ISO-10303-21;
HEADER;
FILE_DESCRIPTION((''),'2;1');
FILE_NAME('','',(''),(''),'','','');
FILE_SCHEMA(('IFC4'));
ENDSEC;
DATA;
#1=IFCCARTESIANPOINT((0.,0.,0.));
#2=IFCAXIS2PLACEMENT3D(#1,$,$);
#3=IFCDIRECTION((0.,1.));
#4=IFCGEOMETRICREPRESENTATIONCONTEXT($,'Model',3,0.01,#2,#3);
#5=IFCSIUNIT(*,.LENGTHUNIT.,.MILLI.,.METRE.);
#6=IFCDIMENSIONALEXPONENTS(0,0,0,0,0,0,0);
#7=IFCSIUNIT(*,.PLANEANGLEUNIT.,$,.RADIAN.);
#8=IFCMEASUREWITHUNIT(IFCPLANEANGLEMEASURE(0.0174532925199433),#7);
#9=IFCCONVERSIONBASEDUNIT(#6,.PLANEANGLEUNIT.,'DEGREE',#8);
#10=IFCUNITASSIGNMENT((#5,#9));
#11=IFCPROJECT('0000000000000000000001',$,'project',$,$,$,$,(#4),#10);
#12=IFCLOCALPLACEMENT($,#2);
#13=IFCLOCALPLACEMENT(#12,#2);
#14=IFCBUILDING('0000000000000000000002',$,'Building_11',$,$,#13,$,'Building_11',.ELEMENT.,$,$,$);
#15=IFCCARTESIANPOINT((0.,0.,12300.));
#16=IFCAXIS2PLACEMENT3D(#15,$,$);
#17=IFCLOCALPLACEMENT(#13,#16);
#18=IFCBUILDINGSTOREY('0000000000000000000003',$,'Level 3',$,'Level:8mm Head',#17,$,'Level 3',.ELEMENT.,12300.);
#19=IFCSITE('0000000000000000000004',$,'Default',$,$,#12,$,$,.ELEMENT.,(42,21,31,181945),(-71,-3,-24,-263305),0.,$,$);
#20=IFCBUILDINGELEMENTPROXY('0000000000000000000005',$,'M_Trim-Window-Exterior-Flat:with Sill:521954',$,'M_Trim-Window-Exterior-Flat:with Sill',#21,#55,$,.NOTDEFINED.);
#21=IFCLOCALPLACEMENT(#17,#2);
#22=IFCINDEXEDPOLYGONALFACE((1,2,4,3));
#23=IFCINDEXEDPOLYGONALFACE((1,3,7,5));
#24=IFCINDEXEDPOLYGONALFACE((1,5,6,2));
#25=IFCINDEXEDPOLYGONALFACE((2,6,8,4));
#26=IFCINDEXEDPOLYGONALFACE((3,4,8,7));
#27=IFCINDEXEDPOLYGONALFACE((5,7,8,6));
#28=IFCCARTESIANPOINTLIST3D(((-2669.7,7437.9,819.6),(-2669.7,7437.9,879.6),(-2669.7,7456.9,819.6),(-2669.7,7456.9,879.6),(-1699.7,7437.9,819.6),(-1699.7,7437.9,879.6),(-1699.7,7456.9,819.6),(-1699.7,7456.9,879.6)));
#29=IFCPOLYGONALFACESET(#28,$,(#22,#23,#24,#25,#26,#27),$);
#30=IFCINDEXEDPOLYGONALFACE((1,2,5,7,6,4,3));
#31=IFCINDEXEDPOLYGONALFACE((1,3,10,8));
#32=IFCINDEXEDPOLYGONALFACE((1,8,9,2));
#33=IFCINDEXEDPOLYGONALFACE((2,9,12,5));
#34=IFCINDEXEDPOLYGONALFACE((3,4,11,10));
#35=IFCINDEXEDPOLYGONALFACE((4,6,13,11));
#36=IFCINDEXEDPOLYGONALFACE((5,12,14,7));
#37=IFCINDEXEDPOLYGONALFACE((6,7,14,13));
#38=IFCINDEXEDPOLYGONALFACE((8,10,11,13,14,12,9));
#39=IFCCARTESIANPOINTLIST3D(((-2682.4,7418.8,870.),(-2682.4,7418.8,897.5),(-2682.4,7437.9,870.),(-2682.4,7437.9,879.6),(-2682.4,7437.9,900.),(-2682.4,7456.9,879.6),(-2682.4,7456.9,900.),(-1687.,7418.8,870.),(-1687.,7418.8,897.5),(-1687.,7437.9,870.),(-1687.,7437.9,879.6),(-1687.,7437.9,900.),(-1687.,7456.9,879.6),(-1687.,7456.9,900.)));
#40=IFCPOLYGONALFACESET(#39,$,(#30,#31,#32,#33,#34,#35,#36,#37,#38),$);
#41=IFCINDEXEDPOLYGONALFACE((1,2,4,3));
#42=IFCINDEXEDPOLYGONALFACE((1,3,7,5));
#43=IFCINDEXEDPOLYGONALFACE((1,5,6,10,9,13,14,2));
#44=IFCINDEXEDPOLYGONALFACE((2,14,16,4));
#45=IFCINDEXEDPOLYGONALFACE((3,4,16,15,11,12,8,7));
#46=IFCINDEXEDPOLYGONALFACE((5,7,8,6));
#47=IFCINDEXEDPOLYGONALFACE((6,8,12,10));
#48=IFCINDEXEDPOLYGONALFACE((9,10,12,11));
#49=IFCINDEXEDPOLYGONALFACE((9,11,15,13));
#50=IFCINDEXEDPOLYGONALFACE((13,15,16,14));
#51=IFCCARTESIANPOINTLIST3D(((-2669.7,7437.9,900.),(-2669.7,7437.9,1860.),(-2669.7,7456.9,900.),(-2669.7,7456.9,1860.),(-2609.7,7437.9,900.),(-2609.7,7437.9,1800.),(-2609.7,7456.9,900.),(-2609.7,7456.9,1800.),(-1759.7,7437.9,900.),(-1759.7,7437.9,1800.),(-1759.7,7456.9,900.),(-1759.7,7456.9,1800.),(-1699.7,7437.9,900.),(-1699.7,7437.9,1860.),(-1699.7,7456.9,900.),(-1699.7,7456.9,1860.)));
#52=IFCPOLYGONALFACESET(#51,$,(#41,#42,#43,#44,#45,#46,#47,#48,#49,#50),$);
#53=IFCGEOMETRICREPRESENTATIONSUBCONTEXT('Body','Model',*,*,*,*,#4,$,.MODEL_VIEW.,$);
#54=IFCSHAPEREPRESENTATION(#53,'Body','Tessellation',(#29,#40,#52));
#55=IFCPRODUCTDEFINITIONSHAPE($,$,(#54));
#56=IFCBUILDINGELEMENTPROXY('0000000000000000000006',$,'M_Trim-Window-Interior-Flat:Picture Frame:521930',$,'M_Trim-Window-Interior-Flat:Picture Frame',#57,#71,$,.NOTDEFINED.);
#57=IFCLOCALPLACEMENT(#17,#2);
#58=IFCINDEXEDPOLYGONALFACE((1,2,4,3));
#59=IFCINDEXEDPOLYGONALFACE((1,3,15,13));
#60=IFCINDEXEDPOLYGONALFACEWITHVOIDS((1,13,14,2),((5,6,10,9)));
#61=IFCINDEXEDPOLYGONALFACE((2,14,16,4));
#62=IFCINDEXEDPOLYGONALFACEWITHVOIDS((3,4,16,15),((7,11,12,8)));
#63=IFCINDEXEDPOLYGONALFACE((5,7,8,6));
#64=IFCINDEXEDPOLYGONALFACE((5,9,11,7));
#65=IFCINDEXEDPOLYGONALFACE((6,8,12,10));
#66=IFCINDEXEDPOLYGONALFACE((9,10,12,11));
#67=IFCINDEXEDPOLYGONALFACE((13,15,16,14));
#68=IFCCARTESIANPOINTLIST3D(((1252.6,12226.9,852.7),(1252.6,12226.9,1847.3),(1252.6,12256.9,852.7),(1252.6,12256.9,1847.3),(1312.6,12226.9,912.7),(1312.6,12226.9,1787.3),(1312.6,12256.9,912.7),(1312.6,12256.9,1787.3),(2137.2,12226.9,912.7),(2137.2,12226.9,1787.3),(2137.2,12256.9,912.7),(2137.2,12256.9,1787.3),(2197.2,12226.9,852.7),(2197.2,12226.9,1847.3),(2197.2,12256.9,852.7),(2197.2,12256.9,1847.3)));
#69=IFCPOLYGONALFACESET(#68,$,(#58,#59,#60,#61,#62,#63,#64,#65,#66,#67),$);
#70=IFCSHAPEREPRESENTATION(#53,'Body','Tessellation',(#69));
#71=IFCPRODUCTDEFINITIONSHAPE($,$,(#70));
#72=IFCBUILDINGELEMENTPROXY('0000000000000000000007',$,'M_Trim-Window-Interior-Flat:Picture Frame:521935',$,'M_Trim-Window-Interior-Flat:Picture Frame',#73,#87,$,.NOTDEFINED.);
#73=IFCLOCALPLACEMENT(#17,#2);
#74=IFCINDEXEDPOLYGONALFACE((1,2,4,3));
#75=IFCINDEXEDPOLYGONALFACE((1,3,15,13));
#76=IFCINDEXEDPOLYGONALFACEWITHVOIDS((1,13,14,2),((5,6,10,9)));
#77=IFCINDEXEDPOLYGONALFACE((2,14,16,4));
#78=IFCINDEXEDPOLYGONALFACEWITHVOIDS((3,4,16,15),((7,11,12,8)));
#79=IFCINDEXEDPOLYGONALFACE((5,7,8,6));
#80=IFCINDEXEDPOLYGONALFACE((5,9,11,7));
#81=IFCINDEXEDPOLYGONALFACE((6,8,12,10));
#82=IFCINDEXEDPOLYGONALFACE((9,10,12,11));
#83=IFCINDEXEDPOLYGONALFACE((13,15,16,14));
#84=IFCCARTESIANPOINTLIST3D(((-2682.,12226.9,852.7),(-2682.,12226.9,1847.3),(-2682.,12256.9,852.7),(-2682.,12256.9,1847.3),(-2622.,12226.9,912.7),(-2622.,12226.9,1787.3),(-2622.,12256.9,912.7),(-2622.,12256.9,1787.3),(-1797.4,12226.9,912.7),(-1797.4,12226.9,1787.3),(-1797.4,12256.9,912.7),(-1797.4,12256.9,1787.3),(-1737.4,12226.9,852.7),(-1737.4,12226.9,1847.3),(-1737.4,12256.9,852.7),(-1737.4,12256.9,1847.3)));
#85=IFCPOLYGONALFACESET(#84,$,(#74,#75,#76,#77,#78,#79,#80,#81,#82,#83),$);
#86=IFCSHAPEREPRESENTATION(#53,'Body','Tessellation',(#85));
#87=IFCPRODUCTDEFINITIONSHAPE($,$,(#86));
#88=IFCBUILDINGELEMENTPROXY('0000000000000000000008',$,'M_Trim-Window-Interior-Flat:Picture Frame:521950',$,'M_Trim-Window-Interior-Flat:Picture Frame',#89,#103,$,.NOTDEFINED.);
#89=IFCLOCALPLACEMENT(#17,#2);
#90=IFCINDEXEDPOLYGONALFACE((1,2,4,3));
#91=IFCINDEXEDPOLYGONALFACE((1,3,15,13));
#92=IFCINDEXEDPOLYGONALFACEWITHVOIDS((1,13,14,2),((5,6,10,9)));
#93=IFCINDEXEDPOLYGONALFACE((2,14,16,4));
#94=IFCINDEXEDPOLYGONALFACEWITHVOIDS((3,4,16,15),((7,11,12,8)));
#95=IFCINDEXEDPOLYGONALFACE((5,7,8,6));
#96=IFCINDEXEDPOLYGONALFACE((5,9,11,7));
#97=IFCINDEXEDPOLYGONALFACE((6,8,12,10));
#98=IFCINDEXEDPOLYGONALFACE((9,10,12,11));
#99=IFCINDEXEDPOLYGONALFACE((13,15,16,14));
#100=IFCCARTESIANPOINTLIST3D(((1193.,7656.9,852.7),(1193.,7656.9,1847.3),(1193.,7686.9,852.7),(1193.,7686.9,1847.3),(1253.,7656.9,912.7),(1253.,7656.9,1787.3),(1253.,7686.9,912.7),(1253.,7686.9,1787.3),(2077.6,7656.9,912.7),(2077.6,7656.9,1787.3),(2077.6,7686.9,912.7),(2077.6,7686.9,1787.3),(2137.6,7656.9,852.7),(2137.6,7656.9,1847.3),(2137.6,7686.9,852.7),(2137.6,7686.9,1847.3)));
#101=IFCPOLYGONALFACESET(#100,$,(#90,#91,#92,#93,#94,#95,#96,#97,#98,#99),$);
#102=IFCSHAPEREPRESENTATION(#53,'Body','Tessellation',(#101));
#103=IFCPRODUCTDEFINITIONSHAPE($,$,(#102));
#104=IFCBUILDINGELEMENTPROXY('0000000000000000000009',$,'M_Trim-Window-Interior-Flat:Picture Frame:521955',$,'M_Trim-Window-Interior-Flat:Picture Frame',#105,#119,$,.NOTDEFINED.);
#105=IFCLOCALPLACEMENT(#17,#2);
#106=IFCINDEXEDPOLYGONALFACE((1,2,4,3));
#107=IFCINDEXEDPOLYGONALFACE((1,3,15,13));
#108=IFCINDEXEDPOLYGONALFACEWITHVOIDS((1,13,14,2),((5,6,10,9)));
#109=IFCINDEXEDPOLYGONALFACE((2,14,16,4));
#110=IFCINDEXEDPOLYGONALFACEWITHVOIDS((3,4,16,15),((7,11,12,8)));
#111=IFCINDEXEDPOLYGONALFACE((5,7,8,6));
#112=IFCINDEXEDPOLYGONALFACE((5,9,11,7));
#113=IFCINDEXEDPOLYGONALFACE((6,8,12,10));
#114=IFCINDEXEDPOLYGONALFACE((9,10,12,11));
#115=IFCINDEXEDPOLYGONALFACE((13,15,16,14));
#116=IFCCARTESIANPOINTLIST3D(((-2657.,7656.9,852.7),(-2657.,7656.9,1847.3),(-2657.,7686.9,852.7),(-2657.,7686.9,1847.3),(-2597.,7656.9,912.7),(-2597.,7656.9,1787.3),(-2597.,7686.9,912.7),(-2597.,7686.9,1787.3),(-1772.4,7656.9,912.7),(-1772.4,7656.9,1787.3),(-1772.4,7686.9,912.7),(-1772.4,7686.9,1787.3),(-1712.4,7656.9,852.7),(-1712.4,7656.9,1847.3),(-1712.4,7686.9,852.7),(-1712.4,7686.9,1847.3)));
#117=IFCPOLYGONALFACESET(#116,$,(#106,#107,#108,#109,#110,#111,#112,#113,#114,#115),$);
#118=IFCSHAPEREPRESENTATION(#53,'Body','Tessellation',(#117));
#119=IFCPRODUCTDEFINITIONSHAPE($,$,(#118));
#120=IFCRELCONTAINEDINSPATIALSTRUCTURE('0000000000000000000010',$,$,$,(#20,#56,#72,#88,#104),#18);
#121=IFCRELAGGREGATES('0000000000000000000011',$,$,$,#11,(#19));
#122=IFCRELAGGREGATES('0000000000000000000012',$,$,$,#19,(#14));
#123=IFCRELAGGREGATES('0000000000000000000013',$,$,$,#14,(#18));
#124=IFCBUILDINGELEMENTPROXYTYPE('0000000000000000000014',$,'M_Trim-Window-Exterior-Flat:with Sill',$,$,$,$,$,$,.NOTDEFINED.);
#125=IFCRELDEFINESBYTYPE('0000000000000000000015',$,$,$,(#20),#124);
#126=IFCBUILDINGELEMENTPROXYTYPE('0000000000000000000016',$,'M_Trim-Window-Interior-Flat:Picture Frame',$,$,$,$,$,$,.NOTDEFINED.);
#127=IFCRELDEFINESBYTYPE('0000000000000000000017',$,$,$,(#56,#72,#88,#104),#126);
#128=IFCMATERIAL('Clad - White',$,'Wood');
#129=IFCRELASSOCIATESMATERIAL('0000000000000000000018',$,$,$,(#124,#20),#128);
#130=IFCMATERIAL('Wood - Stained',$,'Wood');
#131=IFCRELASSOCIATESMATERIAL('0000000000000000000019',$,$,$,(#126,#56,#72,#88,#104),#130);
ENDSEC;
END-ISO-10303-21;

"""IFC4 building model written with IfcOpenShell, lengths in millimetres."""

from ifc_helpers import new_model, entity, si_unit, converted_unit, direction, frame, origin, place, context, subcontext, project, spatial, indexed_curve, outline, extrude, source, transform, mapped, material, type_object, type_shapes, element, save


model = new_model("IFC4")

# Units and contexts
model_context = context("Model", 3, precision=0.01, world=origin(), true_north=direction((0.0, 1.0)))
body_context = subcontext(model_context, "Body", "Model", "MODEL_VIEW")
ifc_project = project(units=[si_unit("LENGTHUNIT", "METRE", prefix="MILLI"), converted_unit("PLANEANGLEUNIT", "DEGREE", entity("IfcPlaneAngleMeasure", 0.0174532925199433), si_unit("PLANEANGLEUNIT", "RADIAN"), dimensions=[0, 0, 0, 0, 0, 0, 0])], contexts=[model_context])

# Site, building, storey
site_placement = place(None, origin())
site = spatial("IfcSite", under=ifc_project, at=site_placement, Name="Default", CompositionType="ELEMENT", RefLatitude=(42, 21, 31, 181945), RefLongitude=(-71, -3, -24, -263305), RefElevation=0.0)
building_placement = place(site_placement, origin())
building = spatial("IfcBuilding", under=site, at=building_placement, Name="Building_11", LongName="Building_11", CompositionType="ELEMENT")
storey_placement = place(building_placement, frame((0.0, 0.0, 12300.0)))
storey = spatial("IfcBuildingStorey", under=building, at=storey_placement, Name="Level 3", ObjectType="Level:8mm Head", LongName="Level 3", CompositionType="ELEMENT", Elevation=12300.0)

# Building element proxies
ifc_material_1 = material(Name="Clad - White", Category="Wood")
ifc_material_2 = material(Name="Wood - Stained", Category="Wood")
building_element_proxy_type_1 = type_object("IfcBuildingElementProxyType", Name="M_Trim-Window-Exterior-Flat:with Sill", PredefinedType="NOTDEFINED", material=ifc_material_1)
shared_shape_1 = source(origin(), body_context, "Body", "SweptSolid", [
    extrude(outline(indexed_curve([(-485.0, -30.0), (485.0, -30.0), (485.0, 30.0), (-485.0, 30.0), (-485.0, -30.0)], self_intersect=False)), frame((0.0, -950.4, 0.0), z_axis=(0.0, 0.0, 1.0), x_axis=(-1.0, 0.0, 0.0)), (0.0, 0.0, 1.0), 19.1),
    extrude(outline(indexed_curve([(-19.0, -15.2), (0.0, -15.2), (0.0, -5.7), (19.0, -5.7), (19.0, 14.8), (0.0, 14.8), (-19.0, 12.3), (-19.0, -15.2)], self_intersect=False)), frame((-497.7, -914.8, 19.0), z_axis=(1.0, 0.0, 0.0), x_axis=(0.0, 0.0, -1.0)), (0.0, 0.0, 1.0), 995.4),
    extrude(outline(indexed_curve([(-495.0, -485.0), (465.0, -485.0), (465.0, -425.0), (-435.0, -425.0), (-435.0, 425.0), (465.0, 425.0), (465.0, 485.0), (-495.0, 485.0), (-495.0, -485.0)], self_intersect=False)), frame((0.0, -435.0, 0.0), z_axis=(0.0, 0.0, 1.0), x_axis=(0.0, -1.0, 0.0)), (0.0, 0.0, 1.0), 19.1),
])
type_shapes(building_element_proxy_type_1, [shared_shape_1])
for number, where, z_axis, x_axis, name in (
    (1, (-2184.7, 7456.9, 1800.0), (0.0, -1.0, 0.0), (1.0, 0.0, 0.0), "M_Trim-Window-Exterior-Flat:with Sill:521954"),
):
    element("IfcBuildingElementProxy", number, at=place(storey_placement, frame(where, z_axis=z_axis, x_axis=x_axis)), inside=storey, type_object=building_element_proxy_type_1, material=ifc_material_1, Name=name, ObjectType="M_Trim-Window-Exterior-Flat:with Sill", PredefinedType="NOTDEFINED", context=body_context, shape_type="MappedRepresentation", body=[
        mapped(shared_shape_1, transform((0.0, 0.0, 0.0), scale=1.0)),
    ])
building_element_proxy_type_2 = type_object("IfcBuildingElementProxyType", Name="M_Trim-Window-Interior-Flat:Picture Frame", PredefinedType="NOTDEFINED", material=ifc_material_2)
shared_shape_2 = source(origin(), body_context, "Body", "SweptSolid", [
    extrude(outline(indexed_curve([(-472.3, -497.3), (472.3, -497.3), (472.3, 497.3), (-472.3, 497.3), (-472.3, -497.3)], self_intersect=False), holes=[indexed_curve([(-412.3, -437.3), (-412.3, 437.3), (412.3, 437.3), (412.3, -437.3), (-412.3, -437.3)], self_intersect=False)]), frame((0.0, -450.0, 0.0), z_axis=(0.0, 0.0, 1.0), x_axis=(-1.0, 0.0, 0.0)), (0.0, 0.0, 1.0), 30.0),
])
type_shapes(building_element_proxy_type_2, [shared_shape_2])
for number, where, z_axis, x_axis, name in (
    (2, (1724.9, 12256.9, 1800.0), (0.0, -1.0, 0.0), (1.0, 0.0, 0.0), "M_Trim-Window-Interior-Flat:Picture Frame:521930"),
    (3, (-2209.7, 12256.9, 1800.0), (0.0, -1.0, 0.0), (1.0, 0.0, 0.0), "M_Trim-Window-Interior-Flat:Picture Frame:521935"),
    (4, (1665.3, 7656.9, 1800.0), (0.0, 1.0, 0.0), (-1.0, 0.0, 0.0), "M_Trim-Window-Interior-Flat:Picture Frame:521950"),
    (5, (-2184.7, 7656.9, 1800.0), (0.0, 1.0, 0.0), (-1.0, 0.0, 0.0), "M_Trim-Window-Interior-Flat:Picture Frame:521955"),
):
    element("IfcBuildingElementProxy", number, at=place(storey_placement, frame(where, z_axis=z_axis, x_axis=x_axis)), inside=storey, type_object=building_element_proxy_type_2, material=ifc_material_2, Name=name, ObjectType="M_Trim-Window-Interior-Flat:Picture Frame", PredefinedType="NOTDEFINED", context=body_context, shape_type="MappedRepresentation", body=[
        mapped(shared_shape_2, transform((0.0, 0.0, 0.0), scale=1.0)),
    ])

save(model, "model.ifc")
